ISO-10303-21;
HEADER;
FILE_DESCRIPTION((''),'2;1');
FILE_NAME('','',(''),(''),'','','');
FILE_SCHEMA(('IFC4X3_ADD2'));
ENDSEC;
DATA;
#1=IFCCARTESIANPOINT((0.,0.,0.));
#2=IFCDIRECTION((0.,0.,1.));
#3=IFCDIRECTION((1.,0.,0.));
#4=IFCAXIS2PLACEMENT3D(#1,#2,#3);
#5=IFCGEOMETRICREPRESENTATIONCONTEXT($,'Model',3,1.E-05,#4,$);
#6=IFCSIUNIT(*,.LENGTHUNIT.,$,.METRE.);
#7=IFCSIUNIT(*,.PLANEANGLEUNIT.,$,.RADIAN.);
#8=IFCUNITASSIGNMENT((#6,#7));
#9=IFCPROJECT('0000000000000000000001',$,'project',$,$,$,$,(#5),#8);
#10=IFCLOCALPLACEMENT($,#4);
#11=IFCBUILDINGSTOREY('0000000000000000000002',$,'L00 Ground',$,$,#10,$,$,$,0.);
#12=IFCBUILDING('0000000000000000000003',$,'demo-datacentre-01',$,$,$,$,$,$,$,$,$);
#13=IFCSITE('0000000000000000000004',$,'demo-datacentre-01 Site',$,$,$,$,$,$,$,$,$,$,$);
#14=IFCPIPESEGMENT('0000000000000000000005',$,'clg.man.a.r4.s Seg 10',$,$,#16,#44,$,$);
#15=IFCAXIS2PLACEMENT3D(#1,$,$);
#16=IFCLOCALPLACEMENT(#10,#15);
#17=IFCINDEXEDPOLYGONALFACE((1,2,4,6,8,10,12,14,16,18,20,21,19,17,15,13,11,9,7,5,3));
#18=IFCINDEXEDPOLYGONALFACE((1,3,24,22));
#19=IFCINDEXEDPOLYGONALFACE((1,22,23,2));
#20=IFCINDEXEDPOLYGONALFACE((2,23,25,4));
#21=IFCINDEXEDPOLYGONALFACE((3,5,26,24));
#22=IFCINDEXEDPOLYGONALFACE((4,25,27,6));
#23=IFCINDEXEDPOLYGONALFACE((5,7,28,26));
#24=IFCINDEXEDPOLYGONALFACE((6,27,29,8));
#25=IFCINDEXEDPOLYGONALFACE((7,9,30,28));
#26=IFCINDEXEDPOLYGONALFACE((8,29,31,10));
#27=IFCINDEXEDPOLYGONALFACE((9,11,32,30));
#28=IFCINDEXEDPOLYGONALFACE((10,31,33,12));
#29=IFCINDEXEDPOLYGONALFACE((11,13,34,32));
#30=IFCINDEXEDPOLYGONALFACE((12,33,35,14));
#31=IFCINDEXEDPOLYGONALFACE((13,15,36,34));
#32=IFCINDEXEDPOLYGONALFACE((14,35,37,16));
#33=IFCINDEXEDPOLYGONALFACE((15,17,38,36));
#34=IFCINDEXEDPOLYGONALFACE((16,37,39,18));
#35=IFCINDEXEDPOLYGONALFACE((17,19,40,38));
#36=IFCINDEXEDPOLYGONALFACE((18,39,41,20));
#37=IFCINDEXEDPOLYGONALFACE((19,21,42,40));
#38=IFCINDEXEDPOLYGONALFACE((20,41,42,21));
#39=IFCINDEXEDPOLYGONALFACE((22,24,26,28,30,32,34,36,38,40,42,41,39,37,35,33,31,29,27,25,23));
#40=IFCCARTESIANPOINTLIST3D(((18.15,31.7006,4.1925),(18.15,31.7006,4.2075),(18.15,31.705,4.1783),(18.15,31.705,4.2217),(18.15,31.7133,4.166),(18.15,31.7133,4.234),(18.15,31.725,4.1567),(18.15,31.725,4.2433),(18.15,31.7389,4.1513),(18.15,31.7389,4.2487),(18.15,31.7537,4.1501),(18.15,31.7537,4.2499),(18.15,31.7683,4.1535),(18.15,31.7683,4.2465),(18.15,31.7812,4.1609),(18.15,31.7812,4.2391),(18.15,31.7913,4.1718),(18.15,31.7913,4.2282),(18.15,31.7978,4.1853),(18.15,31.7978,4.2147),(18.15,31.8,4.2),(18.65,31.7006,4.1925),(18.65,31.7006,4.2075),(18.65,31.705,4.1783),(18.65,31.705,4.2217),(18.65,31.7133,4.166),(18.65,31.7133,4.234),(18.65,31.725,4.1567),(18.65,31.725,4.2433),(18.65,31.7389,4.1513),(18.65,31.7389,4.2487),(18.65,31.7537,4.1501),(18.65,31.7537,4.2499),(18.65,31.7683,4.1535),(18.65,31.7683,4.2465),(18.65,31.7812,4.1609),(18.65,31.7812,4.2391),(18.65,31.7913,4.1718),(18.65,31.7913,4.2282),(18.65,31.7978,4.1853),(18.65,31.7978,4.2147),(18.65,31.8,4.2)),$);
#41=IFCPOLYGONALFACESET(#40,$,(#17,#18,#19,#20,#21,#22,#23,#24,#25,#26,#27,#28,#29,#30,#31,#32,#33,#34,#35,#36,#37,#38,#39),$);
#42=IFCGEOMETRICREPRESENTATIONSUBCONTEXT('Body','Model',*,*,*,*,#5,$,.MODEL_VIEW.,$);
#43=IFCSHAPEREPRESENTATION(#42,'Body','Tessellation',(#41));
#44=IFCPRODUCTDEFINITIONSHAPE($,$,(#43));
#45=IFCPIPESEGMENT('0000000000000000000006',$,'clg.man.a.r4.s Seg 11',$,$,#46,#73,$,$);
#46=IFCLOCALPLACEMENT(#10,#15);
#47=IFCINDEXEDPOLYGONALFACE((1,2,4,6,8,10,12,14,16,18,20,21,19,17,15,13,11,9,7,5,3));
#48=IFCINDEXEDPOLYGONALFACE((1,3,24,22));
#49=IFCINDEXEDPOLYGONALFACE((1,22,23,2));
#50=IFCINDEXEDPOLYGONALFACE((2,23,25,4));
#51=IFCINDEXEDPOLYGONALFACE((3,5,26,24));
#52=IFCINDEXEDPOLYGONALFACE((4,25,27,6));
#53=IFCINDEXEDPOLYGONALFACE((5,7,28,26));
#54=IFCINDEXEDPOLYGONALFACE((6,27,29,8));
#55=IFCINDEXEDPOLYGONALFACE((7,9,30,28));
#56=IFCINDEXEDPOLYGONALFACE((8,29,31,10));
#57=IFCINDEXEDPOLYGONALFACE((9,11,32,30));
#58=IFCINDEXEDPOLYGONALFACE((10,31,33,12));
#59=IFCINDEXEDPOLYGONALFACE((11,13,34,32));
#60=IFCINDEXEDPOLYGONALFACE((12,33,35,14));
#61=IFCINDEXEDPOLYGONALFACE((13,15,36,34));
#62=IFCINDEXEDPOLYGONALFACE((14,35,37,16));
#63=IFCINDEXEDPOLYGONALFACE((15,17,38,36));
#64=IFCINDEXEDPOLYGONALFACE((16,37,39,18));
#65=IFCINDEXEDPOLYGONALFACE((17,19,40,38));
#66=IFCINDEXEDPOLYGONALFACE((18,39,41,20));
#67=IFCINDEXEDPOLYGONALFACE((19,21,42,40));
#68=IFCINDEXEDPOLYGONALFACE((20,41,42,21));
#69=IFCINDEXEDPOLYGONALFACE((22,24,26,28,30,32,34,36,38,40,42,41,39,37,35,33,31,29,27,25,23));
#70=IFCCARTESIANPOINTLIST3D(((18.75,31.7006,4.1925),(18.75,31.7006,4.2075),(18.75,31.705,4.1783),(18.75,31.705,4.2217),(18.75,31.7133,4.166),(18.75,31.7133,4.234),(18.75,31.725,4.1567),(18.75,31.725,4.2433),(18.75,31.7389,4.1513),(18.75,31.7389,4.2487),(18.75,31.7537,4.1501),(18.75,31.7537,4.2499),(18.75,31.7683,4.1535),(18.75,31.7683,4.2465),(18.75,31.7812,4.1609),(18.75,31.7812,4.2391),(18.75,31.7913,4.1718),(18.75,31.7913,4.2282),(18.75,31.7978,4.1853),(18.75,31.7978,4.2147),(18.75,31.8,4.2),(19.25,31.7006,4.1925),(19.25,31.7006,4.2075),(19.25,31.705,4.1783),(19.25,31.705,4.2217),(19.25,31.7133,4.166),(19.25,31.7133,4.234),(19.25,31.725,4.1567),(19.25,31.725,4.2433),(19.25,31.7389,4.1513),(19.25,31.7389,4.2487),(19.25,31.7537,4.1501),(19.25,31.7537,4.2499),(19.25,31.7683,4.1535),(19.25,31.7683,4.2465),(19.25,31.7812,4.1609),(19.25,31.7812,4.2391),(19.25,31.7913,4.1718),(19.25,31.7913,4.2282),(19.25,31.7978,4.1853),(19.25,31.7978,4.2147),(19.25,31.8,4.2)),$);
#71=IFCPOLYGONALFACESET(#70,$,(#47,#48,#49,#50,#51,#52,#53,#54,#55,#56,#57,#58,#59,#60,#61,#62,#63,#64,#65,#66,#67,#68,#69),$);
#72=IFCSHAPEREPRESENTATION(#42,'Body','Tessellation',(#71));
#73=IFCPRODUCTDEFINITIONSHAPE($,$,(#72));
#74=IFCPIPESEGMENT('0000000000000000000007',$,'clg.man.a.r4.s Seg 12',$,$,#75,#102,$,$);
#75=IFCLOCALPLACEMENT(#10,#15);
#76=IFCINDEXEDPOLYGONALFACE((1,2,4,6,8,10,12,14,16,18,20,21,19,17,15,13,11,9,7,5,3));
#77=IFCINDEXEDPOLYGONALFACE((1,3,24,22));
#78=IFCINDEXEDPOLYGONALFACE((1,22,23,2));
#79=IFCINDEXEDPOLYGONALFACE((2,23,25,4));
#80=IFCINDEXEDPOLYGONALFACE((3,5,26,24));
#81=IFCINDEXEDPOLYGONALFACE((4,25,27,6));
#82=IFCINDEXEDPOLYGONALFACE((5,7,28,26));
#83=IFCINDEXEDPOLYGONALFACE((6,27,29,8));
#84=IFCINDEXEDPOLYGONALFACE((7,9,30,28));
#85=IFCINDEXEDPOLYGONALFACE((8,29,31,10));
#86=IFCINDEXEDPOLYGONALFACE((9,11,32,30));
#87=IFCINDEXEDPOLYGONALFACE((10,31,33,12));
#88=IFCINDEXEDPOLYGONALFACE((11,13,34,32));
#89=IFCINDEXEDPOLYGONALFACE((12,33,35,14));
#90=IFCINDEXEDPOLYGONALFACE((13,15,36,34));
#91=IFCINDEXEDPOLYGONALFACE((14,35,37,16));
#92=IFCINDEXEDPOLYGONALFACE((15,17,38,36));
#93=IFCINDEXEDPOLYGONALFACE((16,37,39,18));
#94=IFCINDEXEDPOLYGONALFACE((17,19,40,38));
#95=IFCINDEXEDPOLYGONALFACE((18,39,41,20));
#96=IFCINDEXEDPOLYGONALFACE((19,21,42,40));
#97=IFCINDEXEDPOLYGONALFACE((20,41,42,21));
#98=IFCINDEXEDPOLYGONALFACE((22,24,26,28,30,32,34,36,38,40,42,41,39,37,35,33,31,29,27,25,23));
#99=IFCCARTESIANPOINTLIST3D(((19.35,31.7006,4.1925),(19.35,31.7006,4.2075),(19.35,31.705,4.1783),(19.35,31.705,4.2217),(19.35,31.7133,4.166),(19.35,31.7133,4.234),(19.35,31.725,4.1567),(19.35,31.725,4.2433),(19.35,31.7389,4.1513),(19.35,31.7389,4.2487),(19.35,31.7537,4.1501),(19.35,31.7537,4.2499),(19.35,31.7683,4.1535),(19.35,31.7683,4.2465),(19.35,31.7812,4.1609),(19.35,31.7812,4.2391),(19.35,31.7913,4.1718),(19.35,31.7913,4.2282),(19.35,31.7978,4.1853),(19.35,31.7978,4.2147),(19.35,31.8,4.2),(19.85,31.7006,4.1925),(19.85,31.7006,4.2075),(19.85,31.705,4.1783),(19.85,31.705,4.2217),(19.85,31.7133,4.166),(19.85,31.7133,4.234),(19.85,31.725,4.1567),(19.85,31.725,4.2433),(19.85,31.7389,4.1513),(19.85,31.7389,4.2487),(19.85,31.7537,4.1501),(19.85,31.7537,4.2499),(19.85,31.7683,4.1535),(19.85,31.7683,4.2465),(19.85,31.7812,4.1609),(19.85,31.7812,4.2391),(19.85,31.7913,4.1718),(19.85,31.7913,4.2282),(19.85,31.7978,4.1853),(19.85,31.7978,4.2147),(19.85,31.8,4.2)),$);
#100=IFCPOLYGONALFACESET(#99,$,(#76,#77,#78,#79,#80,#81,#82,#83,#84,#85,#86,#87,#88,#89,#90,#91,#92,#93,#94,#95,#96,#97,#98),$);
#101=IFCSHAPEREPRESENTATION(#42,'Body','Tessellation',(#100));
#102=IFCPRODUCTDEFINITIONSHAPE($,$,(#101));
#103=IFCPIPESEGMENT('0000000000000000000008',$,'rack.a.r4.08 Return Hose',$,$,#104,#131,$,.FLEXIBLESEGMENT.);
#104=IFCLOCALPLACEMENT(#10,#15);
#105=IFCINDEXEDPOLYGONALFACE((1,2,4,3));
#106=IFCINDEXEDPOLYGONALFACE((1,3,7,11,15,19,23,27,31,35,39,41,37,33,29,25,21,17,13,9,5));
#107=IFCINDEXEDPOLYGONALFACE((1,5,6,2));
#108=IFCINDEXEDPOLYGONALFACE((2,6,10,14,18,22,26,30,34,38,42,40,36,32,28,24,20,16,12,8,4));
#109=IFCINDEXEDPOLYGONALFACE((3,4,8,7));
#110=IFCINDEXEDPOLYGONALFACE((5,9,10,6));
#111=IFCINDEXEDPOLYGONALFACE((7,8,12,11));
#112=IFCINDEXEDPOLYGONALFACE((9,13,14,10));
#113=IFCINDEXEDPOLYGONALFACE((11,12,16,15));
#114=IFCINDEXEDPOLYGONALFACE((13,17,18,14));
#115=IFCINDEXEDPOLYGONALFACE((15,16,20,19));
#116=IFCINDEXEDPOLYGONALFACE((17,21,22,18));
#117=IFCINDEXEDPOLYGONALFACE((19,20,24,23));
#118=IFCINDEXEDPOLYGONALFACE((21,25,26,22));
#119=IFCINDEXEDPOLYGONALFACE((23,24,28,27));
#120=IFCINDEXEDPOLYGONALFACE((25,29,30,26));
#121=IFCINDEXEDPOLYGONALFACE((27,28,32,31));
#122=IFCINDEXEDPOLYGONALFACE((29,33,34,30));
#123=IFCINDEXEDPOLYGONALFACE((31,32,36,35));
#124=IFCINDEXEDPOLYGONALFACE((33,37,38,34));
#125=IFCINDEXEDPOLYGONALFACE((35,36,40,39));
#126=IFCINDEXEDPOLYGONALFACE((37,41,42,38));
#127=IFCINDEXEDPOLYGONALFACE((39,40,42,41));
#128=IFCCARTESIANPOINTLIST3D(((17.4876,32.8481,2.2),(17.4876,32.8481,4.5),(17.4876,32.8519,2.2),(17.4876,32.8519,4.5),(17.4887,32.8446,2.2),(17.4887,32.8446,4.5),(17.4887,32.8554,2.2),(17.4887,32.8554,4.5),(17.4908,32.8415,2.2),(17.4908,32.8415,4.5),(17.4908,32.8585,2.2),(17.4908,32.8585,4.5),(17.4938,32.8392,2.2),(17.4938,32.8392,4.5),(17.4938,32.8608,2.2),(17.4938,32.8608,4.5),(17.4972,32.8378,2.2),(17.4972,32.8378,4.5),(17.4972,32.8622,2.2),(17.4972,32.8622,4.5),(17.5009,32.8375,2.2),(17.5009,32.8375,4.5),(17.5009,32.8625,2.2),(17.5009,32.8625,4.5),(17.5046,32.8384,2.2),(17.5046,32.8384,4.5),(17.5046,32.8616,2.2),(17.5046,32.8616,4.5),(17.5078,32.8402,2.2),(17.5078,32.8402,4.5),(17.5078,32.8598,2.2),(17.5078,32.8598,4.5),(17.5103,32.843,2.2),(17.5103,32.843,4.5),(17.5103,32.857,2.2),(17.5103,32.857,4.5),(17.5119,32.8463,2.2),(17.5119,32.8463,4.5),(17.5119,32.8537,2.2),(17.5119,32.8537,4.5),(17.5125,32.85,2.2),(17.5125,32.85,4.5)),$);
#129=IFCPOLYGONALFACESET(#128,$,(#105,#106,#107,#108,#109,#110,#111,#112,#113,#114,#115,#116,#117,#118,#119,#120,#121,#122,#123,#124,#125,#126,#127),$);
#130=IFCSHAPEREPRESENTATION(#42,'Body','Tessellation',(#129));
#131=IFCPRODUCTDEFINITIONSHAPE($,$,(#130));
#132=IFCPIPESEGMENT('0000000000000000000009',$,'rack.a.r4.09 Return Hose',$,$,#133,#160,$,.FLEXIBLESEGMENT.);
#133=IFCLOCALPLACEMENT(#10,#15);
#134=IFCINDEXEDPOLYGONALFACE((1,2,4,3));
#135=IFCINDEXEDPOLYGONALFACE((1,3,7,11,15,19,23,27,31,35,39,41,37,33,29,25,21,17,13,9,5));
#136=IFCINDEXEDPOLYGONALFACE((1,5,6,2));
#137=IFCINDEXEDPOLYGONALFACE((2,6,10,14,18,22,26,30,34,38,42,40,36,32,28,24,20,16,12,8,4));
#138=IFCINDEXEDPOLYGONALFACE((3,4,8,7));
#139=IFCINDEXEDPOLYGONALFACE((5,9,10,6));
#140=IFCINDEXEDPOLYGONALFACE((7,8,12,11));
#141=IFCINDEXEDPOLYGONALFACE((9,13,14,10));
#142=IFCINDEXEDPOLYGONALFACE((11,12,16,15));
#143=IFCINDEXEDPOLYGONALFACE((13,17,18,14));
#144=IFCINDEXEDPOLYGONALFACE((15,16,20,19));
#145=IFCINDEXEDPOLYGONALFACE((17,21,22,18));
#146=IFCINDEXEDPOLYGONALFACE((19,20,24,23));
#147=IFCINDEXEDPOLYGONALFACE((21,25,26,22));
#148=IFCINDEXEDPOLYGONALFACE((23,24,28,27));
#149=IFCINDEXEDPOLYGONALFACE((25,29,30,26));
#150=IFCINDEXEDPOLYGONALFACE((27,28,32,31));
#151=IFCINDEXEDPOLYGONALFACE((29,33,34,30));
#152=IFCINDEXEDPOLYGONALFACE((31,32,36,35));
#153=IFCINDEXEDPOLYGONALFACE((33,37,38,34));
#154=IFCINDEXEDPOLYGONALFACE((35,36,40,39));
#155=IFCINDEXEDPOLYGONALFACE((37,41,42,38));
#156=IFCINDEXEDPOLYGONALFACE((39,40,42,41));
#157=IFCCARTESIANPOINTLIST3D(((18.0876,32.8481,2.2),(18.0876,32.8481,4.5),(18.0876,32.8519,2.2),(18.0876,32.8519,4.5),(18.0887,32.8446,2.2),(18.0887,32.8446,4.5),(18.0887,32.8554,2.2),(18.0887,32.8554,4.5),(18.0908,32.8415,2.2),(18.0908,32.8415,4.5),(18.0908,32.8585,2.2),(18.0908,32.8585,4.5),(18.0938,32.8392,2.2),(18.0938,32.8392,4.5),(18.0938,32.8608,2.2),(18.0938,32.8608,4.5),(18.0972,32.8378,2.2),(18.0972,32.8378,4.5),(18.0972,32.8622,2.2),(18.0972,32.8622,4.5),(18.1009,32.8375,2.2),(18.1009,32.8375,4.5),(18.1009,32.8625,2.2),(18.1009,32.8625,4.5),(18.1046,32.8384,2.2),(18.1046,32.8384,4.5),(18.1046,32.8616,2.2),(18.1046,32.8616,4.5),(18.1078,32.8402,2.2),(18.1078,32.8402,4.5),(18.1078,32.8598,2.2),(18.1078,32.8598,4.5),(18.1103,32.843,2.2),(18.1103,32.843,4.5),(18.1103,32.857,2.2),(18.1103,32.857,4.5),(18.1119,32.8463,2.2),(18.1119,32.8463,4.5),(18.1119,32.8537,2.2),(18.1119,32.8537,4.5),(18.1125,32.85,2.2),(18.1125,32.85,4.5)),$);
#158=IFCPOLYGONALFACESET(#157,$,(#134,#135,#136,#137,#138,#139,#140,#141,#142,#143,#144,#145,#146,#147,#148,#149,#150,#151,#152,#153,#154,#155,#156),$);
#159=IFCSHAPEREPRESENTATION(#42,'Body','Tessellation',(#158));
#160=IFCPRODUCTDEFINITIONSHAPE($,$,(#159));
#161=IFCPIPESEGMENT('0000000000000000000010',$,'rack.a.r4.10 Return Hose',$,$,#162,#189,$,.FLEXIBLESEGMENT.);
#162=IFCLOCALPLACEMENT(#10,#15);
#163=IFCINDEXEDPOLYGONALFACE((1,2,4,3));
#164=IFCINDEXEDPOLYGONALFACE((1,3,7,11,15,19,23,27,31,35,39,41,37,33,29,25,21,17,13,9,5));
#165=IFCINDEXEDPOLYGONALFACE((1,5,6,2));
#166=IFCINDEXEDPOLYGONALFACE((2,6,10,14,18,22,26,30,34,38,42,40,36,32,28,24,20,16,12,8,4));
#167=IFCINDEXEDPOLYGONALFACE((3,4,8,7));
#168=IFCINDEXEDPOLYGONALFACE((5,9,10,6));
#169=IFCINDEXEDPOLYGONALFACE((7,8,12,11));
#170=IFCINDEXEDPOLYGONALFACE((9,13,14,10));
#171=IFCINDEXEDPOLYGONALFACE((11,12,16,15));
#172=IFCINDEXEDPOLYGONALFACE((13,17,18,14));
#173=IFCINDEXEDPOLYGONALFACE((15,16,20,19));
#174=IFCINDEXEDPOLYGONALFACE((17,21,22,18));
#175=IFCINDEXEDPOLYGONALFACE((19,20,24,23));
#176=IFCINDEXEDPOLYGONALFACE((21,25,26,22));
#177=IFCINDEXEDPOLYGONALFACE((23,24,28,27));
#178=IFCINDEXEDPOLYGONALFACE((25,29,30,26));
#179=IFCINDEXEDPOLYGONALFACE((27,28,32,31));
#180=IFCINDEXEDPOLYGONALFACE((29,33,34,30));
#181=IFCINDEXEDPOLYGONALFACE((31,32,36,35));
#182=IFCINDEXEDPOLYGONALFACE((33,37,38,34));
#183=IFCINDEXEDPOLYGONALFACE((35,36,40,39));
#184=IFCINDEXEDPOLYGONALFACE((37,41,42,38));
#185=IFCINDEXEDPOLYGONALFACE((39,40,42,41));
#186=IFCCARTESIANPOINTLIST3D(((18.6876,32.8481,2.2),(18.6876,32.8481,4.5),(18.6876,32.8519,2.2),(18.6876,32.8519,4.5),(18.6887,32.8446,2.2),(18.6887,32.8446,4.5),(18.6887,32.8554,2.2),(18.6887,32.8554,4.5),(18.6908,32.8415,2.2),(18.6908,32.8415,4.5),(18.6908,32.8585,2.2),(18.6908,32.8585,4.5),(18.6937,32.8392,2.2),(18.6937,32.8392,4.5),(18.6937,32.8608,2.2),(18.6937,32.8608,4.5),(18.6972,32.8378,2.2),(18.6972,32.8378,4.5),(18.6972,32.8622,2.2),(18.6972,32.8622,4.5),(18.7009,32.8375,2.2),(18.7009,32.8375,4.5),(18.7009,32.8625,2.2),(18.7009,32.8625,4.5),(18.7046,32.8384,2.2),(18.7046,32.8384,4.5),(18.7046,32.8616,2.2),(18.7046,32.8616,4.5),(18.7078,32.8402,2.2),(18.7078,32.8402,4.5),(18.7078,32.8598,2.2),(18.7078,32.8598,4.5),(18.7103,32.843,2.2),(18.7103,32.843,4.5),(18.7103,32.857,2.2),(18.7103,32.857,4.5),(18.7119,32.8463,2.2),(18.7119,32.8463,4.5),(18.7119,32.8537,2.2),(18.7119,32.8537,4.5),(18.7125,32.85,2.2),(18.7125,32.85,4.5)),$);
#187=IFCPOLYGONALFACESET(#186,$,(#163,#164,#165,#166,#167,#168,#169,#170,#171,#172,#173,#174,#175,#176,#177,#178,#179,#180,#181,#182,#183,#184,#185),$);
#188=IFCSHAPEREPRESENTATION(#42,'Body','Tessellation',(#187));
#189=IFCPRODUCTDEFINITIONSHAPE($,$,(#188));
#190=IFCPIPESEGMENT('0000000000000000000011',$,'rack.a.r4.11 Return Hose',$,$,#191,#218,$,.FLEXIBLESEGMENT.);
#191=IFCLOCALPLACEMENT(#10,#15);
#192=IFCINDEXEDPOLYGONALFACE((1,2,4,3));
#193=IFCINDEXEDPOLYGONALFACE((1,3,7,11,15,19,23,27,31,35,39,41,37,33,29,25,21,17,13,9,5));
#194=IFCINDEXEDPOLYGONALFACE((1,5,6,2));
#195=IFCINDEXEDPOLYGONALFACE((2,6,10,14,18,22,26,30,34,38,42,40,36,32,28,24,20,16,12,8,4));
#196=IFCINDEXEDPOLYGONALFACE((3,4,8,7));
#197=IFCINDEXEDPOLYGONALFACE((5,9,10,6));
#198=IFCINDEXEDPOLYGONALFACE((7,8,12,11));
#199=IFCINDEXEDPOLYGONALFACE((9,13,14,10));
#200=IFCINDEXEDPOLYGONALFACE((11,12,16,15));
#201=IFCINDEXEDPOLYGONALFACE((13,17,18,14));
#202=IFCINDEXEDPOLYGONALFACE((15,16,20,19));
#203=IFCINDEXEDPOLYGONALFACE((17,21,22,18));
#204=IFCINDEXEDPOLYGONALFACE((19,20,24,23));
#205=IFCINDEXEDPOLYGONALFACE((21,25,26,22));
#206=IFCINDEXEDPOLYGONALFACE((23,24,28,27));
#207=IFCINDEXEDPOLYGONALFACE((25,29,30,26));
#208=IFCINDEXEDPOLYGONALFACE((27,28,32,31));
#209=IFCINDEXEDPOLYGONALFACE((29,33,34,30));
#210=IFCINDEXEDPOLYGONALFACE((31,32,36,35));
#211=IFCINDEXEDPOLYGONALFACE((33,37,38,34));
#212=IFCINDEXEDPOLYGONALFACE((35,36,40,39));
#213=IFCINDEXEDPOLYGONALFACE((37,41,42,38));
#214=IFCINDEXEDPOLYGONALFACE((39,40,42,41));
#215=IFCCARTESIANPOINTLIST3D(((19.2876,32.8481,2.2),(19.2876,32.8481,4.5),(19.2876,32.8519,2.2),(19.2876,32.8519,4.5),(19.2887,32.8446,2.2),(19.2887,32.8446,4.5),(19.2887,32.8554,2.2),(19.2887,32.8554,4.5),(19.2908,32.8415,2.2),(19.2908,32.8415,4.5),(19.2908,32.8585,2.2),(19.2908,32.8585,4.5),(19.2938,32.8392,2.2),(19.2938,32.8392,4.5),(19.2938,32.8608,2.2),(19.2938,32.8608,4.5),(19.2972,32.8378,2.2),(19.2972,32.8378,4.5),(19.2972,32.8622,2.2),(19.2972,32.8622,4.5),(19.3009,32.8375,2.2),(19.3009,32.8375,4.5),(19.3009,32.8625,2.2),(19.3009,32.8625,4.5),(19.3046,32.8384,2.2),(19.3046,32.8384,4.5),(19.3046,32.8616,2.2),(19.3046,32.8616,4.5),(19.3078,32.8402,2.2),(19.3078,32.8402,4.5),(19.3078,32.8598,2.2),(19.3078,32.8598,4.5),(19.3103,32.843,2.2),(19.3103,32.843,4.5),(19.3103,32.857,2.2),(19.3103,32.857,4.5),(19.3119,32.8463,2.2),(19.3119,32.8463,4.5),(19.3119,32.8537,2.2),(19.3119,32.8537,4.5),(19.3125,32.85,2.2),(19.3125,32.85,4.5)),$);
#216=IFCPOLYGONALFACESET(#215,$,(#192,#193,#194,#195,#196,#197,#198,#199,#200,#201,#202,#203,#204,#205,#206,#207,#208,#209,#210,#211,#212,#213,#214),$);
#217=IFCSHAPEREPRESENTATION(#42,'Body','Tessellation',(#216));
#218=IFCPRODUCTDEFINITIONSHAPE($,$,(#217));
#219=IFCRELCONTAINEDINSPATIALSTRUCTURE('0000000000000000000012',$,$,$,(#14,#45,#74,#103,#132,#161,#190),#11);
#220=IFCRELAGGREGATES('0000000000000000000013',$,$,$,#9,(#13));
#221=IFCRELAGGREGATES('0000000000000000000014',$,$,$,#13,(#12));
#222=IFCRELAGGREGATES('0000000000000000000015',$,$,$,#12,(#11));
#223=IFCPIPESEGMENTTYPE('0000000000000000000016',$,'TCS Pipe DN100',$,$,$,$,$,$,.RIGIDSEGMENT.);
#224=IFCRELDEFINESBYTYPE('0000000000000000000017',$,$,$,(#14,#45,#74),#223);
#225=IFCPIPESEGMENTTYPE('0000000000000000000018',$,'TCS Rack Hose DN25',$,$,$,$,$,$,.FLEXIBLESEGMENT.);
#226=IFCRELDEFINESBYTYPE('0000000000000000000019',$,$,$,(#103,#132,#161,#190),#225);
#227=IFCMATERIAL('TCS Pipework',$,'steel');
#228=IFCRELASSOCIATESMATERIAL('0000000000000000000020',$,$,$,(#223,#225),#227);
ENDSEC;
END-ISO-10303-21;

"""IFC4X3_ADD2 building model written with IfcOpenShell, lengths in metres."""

from ifc_helpers import new_model, si_unit, frame, origin_with_axes, place, context, subcontext, project, spatial, circle, extrude, material, type_object, element, save


model = new_model("IFC4X3_ADD2")

# Units and contexts
model_context = context("Model", 3, precision=1e-05, world=origin_with_axes())
body_context = subcontext(model_context, "Body", "Model", "MODEL_VIEW")
ifc_project = project(units=[si_unit("LENGTHUNIT", "METRE"), si_unit("PLANEANGLEUNIT", "RADIAN")], contexts=[model_context])

# Site, building, storey
site = spatial("IfcSite", under=ifc_project, Name="demo-datacentre-01 Site")
building = spatial("IfcBuilding", under=site, Name="demo-datacentre-01")
storey_placement = place(None, origin_with_axes())
storey = spatial("IfcBuildingStorey", under=building, at=storey_placement, Name="L00 Ground", Elevation=0.0)

# Shared definitions
ifc_material = material(Name="TCS Pipework", Category="steel")

# Pipe segments
pipe_segment_type_1 = type_object("IfcPipeSegmentType", Name="TCS Pipe DN100", PredefinedType="RIGIDSEGMENT", material=ifc_material)
pipe_segment_1_placement = place(storey_placement, frame((18.15, 31.75, 4.2), z_axis=(1.0, 0.0, 0.0), x_axis=(0.0, 1.0, 0.0)))
element("IfcPipeSegment", 1, at=pipe_segment_1_placement, inside=storey, type_object=pipe_segment_type_1, Name="clg.man.a.r4.s Seg 10", context=body_context, shape_type="SweptSolid", body=[
    extrude(circle(Radius=0.05), origin_with_axes(), (0.0, 0.0, 1.0), 0.5),
])
pipe_segment_2_placement = place(storey_placement, frame((18.75, 31.75, 4.2), z_axis=(1.0, 0.0, 0.0), x_axis=(0.0, 1.0, 0.0)))
element("IfcPipeSegment", 2, at=pipe_segment_2_placement, inside=storey, type_object=pipe_segment_type_1, Name="clg.man.a.r4.s Seg 11", context=body_context, shape_type="SweptSolid", body=[
    extrude(circle(Radius=0.05), origin_with_axes(), (0.0, 0.0, 1.0), 0.5),
])
pipe_segment_3_placement = place(storey_placement, frame((19.35, 31.75, 4.2), z_axis=(1.0, 0.0, 0.0), x_axis=(0.0, 1.0, 0.0)))
element("IfcPipeSegment", 3, at=pipe_segment_3_placement, inside=storey, type_object=pipe_segment_type_1, Name="clg.man.a.r4.s Seg 12", context=body_context, shape_type="SweptSolid", body=[
    extrude(circle(Radius=0.05), origin_with_axes(), (0.0, 0.0, 1.0), 0.5),
])
pipe_segment_type_2 = type_object("IfcPipeSegmentType", Name="TCS Rack Hose DN25", PredefinedType="FLEXIBLESEGMENT", material=ifc_material)
for number, where, z_axis, x_axis, name in (
    (4, (17.5, 32.85, 4.5), (0.0, 0.0, -1.0), (1.0, 0.0, 0.0), "rack.a.r4.08 Return Hose"),
    (5, (18.1, 32.85, 4.5), (0.0, 0.0, -1.0), (1.0, 0.0, 0.0), "rack.a.r4.09 Return Hose"),
    (6, (18.7, 32.85, 4.5), (0.0, 0.0, -1.0), (1.0, 0.0, 0.0), "rack.a.r4.10 Return Hose"),
    (7, (19.3, 32.85, 4.5), (0.0, 0.0, -1.0), (1.0, 0.0, 0.0), "rack.a.r4.11 Return Hose"),
):
    element("IfcPipeSegment", number, at=place(storey_placement, frame(where, z_axis=z_axis, x_axis=x_axis)), inside=storey, type_object=pipe_segment_type_2, Name=name, PredefinedType="FLEXIBLESEGMENT", context=body_context, shape_type="SweptSolid", body=[
        extrude(circle(Radius=0.0125), origin_with_axes(), (0.0, 0.0, 1.0), 2.3),
    ])

save(model, "model.ifc")
